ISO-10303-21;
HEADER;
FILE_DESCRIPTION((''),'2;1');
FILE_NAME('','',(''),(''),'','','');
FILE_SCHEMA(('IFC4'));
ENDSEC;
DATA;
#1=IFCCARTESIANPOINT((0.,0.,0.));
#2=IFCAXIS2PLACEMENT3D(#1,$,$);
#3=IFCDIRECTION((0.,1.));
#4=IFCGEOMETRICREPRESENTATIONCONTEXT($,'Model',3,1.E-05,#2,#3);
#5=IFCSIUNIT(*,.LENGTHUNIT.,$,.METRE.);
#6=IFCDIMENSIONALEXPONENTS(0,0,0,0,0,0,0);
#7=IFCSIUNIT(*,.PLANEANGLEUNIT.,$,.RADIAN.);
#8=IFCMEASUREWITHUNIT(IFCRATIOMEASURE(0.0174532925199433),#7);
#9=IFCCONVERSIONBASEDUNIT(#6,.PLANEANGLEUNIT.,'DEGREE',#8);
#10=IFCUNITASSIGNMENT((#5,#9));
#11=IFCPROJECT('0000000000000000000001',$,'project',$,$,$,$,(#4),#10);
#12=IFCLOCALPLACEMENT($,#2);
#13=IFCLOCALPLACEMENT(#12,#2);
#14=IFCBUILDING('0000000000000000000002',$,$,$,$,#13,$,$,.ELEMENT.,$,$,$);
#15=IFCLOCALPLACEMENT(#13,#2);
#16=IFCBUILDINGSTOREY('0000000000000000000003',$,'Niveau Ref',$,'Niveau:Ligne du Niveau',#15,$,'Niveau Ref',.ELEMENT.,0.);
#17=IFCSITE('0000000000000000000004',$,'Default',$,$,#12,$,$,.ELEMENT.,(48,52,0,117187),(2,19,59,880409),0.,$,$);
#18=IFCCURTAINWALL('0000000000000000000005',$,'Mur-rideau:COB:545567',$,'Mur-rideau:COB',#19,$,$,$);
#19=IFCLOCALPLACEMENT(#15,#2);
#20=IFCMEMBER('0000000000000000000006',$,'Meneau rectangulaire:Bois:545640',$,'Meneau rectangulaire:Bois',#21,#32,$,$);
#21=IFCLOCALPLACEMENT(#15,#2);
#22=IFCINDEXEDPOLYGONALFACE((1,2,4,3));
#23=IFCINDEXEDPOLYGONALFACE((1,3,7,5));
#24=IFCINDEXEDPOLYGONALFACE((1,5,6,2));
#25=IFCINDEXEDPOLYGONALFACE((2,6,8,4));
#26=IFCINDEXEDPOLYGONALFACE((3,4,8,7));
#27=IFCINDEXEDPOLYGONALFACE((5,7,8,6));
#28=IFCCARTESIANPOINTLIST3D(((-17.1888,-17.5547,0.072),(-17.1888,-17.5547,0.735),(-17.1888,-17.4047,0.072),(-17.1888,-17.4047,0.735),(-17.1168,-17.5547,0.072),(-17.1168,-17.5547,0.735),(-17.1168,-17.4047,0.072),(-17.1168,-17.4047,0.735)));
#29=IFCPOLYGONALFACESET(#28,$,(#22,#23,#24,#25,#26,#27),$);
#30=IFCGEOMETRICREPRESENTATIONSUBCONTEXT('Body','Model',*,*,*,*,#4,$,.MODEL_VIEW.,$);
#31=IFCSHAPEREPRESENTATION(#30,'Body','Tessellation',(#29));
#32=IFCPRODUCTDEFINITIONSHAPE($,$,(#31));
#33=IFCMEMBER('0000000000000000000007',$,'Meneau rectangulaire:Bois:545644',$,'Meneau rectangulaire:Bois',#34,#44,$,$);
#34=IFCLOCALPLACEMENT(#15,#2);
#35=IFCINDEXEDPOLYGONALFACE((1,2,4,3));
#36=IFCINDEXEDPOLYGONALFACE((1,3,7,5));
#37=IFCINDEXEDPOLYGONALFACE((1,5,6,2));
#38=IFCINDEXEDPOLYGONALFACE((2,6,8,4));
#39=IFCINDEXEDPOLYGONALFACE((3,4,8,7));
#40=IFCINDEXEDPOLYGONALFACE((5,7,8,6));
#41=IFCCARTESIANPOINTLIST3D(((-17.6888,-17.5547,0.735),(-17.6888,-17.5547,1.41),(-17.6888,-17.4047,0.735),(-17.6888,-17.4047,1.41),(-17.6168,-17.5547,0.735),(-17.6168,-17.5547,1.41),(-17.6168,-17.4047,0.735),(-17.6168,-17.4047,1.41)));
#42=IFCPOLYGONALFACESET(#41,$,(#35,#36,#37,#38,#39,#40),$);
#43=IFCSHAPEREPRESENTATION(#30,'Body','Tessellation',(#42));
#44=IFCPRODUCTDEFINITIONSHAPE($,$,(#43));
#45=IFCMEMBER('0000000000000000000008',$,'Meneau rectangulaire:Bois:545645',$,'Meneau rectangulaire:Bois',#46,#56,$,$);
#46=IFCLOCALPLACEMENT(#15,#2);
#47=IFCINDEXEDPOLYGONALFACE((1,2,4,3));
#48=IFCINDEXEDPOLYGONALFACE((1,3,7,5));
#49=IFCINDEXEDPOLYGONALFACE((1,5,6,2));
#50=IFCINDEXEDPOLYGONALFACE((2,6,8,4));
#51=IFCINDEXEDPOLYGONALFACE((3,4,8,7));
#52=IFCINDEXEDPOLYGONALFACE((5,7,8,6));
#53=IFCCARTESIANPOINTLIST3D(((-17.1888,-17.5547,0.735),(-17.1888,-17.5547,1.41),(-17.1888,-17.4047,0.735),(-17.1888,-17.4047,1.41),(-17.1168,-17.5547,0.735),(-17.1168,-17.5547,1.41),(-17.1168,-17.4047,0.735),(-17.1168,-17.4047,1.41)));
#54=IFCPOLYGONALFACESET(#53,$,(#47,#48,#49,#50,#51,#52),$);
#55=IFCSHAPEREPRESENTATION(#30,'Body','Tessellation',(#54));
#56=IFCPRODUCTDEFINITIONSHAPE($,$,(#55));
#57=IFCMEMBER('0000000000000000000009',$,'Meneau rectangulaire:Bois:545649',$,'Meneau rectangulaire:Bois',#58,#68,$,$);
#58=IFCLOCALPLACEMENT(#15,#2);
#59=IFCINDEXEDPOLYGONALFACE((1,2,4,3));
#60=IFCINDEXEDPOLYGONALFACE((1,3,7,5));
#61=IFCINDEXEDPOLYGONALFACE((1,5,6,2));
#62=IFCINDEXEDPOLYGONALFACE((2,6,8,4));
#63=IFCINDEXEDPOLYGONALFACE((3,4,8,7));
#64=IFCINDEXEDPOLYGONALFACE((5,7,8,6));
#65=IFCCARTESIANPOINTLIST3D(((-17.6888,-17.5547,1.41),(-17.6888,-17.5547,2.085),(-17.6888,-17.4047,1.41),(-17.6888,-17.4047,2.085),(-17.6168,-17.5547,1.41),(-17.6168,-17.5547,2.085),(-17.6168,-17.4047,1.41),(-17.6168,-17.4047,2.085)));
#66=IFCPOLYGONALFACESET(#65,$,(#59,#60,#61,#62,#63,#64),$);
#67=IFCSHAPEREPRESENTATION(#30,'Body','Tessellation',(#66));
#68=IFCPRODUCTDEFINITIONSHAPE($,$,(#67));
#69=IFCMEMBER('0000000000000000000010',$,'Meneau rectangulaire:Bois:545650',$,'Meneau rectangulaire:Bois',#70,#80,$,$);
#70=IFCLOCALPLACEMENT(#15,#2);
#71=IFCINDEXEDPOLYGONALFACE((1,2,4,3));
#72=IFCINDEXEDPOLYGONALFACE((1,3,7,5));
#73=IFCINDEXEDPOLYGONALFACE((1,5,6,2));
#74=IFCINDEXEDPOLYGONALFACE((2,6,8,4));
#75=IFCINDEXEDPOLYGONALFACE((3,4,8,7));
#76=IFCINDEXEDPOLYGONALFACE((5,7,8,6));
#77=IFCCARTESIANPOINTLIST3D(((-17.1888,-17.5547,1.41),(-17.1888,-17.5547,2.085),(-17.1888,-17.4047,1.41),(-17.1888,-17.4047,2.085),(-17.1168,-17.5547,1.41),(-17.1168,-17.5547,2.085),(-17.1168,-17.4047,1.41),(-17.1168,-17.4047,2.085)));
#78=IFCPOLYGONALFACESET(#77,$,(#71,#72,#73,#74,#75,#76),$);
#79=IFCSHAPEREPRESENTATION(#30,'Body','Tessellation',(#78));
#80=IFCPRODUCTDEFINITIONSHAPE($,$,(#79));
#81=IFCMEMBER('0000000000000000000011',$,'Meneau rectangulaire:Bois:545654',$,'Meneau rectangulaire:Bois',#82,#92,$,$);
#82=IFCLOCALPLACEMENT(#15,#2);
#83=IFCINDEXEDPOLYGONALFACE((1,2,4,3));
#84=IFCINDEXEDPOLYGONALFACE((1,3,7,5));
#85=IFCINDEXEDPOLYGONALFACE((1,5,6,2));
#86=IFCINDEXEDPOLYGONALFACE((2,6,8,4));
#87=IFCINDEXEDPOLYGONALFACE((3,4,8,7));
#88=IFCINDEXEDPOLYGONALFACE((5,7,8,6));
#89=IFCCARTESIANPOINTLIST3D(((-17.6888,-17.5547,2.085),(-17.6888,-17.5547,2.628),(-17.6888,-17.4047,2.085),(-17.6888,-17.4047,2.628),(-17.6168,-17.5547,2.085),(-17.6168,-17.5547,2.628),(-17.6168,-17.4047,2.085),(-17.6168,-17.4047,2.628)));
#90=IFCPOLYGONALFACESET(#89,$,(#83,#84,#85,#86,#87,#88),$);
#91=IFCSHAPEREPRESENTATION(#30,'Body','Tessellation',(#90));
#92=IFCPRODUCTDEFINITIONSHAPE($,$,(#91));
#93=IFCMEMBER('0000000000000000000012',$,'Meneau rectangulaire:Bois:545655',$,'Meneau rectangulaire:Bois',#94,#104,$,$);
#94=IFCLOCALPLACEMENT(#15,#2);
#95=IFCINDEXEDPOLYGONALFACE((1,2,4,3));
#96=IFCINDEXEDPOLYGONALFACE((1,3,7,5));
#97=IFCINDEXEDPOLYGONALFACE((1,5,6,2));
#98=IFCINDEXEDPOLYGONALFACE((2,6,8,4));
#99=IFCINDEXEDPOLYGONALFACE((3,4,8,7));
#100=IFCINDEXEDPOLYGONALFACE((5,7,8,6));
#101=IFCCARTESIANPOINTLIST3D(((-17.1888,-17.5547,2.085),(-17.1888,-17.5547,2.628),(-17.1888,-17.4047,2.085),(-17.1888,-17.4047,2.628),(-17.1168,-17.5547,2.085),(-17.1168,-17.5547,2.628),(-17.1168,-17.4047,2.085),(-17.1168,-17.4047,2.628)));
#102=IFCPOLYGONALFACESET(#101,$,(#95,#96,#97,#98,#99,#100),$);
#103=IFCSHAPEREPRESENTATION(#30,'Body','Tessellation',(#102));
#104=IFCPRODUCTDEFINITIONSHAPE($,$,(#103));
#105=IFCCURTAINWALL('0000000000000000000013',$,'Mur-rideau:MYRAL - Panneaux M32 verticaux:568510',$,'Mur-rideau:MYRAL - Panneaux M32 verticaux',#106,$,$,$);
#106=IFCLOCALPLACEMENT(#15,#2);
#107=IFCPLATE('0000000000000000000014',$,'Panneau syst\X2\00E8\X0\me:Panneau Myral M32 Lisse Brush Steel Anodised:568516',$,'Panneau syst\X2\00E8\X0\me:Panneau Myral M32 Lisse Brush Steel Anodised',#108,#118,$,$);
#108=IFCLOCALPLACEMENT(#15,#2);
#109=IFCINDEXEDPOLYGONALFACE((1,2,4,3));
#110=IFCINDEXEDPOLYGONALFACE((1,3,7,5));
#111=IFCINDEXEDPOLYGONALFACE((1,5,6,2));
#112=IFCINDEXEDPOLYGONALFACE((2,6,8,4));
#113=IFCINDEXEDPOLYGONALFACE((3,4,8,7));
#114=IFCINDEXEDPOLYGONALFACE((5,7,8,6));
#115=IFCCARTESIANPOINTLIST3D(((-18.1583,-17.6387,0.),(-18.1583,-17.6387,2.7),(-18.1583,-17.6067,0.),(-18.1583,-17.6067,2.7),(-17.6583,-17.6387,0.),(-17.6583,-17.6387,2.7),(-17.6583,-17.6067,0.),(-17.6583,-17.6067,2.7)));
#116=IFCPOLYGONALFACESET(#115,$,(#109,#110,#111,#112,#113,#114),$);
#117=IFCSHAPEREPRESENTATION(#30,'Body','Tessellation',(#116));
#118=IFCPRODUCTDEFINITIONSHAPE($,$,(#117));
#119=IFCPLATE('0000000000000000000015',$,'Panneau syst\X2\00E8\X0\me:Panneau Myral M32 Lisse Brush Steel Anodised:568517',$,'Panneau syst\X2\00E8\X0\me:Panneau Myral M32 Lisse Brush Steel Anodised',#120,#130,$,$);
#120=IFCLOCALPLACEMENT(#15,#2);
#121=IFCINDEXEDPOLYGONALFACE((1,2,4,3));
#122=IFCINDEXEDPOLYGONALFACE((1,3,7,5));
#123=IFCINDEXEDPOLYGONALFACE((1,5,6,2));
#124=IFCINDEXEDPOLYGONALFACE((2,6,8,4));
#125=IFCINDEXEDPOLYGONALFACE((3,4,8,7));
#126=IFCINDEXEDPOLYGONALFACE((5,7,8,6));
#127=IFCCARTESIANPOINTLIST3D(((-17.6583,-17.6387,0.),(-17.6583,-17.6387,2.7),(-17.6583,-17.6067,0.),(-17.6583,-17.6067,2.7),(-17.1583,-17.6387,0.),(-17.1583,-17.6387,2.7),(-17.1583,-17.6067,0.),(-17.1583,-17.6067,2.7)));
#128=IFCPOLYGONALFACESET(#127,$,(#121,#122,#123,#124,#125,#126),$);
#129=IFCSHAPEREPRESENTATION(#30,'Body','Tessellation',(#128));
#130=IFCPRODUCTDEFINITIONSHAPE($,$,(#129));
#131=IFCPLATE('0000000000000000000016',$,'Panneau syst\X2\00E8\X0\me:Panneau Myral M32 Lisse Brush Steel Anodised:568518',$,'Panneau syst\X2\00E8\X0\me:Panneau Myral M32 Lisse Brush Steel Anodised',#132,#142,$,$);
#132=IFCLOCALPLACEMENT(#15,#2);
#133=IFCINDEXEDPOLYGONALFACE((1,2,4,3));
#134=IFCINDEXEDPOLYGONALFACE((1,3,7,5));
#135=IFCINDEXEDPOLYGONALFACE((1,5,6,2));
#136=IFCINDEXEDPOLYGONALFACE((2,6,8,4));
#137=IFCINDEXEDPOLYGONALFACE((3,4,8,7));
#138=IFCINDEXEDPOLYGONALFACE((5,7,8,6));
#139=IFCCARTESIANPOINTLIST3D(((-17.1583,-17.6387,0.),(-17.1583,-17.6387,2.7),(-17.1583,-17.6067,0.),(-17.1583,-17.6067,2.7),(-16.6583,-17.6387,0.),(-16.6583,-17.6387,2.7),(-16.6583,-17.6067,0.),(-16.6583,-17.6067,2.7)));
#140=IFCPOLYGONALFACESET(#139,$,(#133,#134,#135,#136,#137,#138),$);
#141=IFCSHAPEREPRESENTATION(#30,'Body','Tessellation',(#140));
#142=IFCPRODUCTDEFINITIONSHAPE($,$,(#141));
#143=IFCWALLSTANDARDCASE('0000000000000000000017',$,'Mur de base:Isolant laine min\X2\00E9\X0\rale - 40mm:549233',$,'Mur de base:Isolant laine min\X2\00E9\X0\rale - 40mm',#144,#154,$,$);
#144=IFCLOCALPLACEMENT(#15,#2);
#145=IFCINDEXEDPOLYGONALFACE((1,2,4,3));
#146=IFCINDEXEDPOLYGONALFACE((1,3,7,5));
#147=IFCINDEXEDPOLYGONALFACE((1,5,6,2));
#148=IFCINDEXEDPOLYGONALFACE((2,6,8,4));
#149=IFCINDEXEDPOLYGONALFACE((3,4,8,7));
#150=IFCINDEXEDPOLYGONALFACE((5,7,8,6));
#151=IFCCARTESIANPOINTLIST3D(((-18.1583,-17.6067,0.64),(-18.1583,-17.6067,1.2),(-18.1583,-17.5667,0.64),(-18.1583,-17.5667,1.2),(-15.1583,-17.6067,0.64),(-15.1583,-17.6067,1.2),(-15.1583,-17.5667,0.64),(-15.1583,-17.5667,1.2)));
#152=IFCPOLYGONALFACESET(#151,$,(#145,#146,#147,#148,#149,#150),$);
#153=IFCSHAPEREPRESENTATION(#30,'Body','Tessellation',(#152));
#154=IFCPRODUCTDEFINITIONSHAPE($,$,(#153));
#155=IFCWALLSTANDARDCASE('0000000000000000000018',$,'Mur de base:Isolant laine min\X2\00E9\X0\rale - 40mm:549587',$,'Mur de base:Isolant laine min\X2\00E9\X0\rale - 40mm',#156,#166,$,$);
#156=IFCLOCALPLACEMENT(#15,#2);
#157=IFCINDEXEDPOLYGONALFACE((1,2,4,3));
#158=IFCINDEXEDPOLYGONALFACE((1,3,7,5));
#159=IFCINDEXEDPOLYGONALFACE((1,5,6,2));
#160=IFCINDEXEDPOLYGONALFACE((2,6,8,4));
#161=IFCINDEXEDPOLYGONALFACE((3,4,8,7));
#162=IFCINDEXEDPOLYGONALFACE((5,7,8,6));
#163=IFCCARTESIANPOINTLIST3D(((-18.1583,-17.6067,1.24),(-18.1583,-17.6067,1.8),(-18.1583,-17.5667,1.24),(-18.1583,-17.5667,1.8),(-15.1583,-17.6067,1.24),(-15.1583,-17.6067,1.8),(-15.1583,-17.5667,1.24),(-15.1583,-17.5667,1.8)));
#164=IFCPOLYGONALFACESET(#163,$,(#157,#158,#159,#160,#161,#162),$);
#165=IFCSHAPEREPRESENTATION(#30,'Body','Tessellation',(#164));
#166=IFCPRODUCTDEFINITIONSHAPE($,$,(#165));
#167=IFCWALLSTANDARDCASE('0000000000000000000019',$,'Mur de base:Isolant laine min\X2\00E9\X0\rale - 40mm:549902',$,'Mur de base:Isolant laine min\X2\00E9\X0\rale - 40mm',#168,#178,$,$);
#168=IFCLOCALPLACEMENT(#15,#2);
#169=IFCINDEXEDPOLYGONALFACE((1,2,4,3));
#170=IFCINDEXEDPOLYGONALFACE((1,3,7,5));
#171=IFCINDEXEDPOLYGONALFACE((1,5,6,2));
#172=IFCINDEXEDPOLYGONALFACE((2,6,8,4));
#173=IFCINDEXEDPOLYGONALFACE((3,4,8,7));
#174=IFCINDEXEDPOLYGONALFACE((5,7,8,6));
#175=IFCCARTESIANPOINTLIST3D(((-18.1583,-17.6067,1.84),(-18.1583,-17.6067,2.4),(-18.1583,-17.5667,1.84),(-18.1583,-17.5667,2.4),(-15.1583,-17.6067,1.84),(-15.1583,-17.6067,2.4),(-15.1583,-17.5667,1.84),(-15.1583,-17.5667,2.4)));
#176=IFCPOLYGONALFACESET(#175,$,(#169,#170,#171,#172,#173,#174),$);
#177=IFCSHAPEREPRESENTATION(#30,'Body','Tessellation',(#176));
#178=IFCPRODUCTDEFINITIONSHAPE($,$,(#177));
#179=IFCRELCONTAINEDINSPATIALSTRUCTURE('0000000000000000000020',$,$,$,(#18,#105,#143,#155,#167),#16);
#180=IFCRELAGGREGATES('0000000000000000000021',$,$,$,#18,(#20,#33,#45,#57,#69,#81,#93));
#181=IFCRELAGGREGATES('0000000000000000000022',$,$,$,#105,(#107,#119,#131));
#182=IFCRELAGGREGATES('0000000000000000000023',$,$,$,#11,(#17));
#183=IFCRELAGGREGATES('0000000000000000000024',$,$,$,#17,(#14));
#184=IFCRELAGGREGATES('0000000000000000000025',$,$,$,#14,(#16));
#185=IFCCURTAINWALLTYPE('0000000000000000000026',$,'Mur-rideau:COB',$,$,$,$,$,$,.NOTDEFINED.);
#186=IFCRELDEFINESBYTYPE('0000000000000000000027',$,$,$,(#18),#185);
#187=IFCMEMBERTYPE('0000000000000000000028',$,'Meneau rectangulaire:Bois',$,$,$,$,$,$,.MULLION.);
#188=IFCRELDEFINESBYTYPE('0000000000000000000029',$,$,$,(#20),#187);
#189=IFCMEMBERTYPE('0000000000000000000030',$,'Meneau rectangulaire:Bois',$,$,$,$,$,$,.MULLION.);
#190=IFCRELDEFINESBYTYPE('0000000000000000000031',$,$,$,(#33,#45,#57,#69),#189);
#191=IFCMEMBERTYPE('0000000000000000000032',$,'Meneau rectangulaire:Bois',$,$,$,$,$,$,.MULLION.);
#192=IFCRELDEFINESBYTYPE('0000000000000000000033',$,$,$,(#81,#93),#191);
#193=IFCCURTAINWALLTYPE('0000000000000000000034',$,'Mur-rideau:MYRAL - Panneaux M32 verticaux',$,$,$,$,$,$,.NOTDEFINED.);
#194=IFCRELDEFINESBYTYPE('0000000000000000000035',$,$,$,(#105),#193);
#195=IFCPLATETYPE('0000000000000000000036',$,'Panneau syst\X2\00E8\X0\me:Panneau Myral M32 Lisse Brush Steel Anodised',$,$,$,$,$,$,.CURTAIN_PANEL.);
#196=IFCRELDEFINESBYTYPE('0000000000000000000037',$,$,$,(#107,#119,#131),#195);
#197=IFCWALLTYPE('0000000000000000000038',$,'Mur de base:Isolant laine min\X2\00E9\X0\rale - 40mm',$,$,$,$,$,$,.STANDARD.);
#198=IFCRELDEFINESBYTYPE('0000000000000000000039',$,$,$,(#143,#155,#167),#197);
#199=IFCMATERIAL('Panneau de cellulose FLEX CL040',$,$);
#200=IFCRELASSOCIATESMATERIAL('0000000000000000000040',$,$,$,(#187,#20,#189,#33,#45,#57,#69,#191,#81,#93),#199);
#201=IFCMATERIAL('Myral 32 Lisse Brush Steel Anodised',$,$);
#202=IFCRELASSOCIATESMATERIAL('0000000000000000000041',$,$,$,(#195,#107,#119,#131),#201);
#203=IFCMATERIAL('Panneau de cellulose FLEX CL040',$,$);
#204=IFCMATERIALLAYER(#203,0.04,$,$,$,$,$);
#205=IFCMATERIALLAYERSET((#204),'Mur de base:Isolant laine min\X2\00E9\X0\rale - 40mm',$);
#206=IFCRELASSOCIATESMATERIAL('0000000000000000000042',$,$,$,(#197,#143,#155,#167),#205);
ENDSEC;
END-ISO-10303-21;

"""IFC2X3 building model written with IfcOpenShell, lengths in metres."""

from ifc_helpers import new_model, entity, si_unit, converted_unit, direction, frame, frame_2d, origin, origin_2d_with_axis, place, context, subcontext, project, spatial, rectangle, extrude, source, transform, mapped, material, layer, layer_set, layer_usage, type_object, type_shapes, element, aggregate, save


model = new_model("IFC2X3")

# Units and contexts
model_context = context("Model", 3, precision=1e-05, world=origin(), true_north=direction((0.0, 1.0)))
body_context = subcontext(model_context, "Body", "Model", "MODEL_VIEW")
ifc_project = project(units=[si_unit("LENGTHUNIT", "METRE"), converted_unit("PLANEANGLEUNIT", "DEGREE", entity("IfcRatioMeasure", 0.0174532925199433), si_unit("PLANEANGLEUNIT", "RADIAN"), dimensions=[0, 0, 0, 0, 0, 0, 0])], contexts=[model_context])

# Site, building, storey
site_placement = place(None, origin())
site = spatial("IfcSite", under=ifc_project, at=site_placement, Name="Default", CompositionType="ELEMENT", RefLatitude=(48, 52, 0, 117187), RefLongitude=(2, 19, 59, 880409), RefElevation=0.0)
building_placement = place(site_placement, origin())
building = spatial("IfcBuilding", under=site, at=building_placement, CompositionType="ELEMENT")
storey_placement = place(building_placement, origin())
storey = spatial("IfcBuildingStorey", under=building, at=storey_placement, Name="Niveau Ref", ObjectType="Niveau:Ligne du Niveau", LongName="Niveau Ref", CompositionType="ELEMENT", Elevation=0.0)

# Curtain wall, members
curtain_wall_type_1 = type_object("IfcCurtainWallType", Name="Mur-rideau:COB", PredefinedType="NOTDEFINED")
curtain_wall_1_placement = place(storey_placement, origin())
curtain_wall_1 = element("IfcCurtainWall", 1, at=curtain_wall_1_placement, inside=storey, type_object=curtain_wall_type_1, Name="Mur-rideau:COB:545567", ObjectType="Mur-rideau:COB")
ifc_material_1 = material(Name="Panneau de cellulose FLEX CL040")
member_type_1 = type_object("IfcMemberType", Name="Meneau rectangulaire:Bois", PredefinedType="MULLION", material=ifc_material_1)
shared_shape_1 = source(origin(), body_context, "Body", "SweptSolid", [
    extrude(rectangle(XDim=0.15, YDim=0.072, at=origin_2d_with_axis()), frame((-0.024, 0.0, -0.663), z_axis=(0.0, 0.0, 1.0), x_axis=(0.0, -1.0, 0.0)), (0.0, 0.0, 1.0), 0.663),
])
type_shapes(member_type_1, [shared_shape_1])
member_1_placement = place(storey_placement, frame((-17.1288, -17.4797, 0.072), z_axis=(0.0, 0.0, -1.0), x_axis=(1.0, 0.0, 0.0)))
member_1 = element("IfcMember", 2, at=member_1_placement, type_object=member_type_1, material=ifc_material_1, Name="Meneau rectangulaire:Bois:545640", ObjectType="Meneau rectangulaire:Bois", context=body_context, shape_type="MappedRepresentation", body=[
    mapped(shared_shape_1, transform((0.0, 0.0, 0.0), scale=1.0)),
])
member_type_2 = type_object("IfcMemberType", Name="Meneau rectangulaire:Bois", PredefinedType="MULLION", material=ifc_material_1)
shared_shape_2 = source(origin(), body_context, "Body", "SweptSolid", [
    extrude(rectangle(XDim=0.15, YDim=0.072, at=origin_2d_with_axis()), frame((-0.024, 0.0, -0.675), z_axis=(0.0, 0.0, 1.0), x_axis=(0.0, -1.0, 0.0)), (0.0, 0.0, 1.0), 0.675),
])
type_shapes(member_type_2, [shared_shape_2])
member_2_placement = place(storey_placement, frame((-17.6288, -17.4797, 0.735), z_axis=(0.0, 0.0, -1.0), x_axis=(1.0, 0.0, 0.0)))
member_2 = element("IfcMember", 3, at=member_2_placement, type_object=member_type_2, material=ifc_material_1, Name="Meneau rectangulaire:Bois:545644", ObjectType="Meneau rectangulaire:Bois", context=body_context, shape_type="MappedRepresentation", body=[
    mapped(shared_shape_2, transform((0.0, 0.0, 0.0), scale=1.0)),
])
member_3_placement = place(storey_placement, frame((-17.1288, -17.4797, 0.735), z_axis=(0.0, 0.0, -1.0), x_axis=(1.0, 0.0, 0.0)))
member_3 = element("IfcMember", 4, at=member_3_placement, type_object=member_type_2, material=ifc_material_1, Name="Meneau rectangulaire:Bois:545645", ObjectType="Meneau rectangulaire:Bois", context=body_context, shape_type="MappedRepresentation", body=[
    mapped(shared_shape_2, transform((0.0, 0.0, 0.0), scale=1.0)),
])
member_4_placement = place(storey_placement, frame((-17.6288, -17.4797, 1.41), z_axis=(0.0, 0.0, -1.0), x_axis=(1.0, 0.0, 0.0)))
member_4 = element("IfcMember", 5, at=member_4_placement, type_object=member_type_2, material=ifc_material_1, Name="Meneau rectangulaire:Bois:545649", ObjectType="Meneau rectangulaire:Bois", context=body_context, shape_type="MappedRepresentation", body=[
    mapped(shared_shape_2, transform((0.0, 0.0, 0.0), scale=1.0)),
])
member_5_placement = place(storey_placement, frame((-17.1288, -17.4797, 1.41), z_axis=(0.0, 0.0, -1.0), x_axis=(1.0, 0.0, 0.0)))
member_5 = element("IfcMember", 6, at=member_5_placement, type_object=member_type_2, material=ifc_material_1, Name="Meneau rectangulaire:Bois:545650", ObjectType="Meneau rectangulaire:Bois", context=body_context, shape_type="MappedRepresentation", body=[
    mapped(shared_shape_2, transform((0.0, 0.0, 0.0), scale=1.0)),
])
member_type_3 = type_object("IfcMemberType", Name="Meneau rectangulaire:Bois", PredefinedType="MULLION", material=ifc_material_1)
shared_shape_3 = source(origin(), body_context, "Body", "SweptSolid", [
    extrude(rectangle(XDim=0.15, YDim=0.072, at=origin_2d_with_axis()), frame((-0.024, 0.0, -0.543), z_axis=(0.0, 0.0, 1.0), x_axis=(0.0, -1.0, 0.0)), (0.0, 0.0, 1.0), 0.543),
])
type_shapes(member_type_3, [shared_shape_3])
member_6_placement = place(storey_placement, frame((-17.6288, -17.4797, 2.085), z_axis=(0.0, 0.0, -1.0), x_axis=(1.0, 0.0, 0.0)))
member_6 = element("IfcMember", 7, at=member_6_placement, type_object=member_type_3, material=ifc_material_1, Name="Meneau rectangulaire:Bois:545654", ObjectType="Meneau rectangulaire:Bois", context=body_context, shape_type="MappedRepresentation", body=[
    mapped(shared_shape_3, transform((0.0, 0.0, 0.0), scale=1.0)),
])
member_7_placement = place(storey_placement, frame((-17.1288, -17.4797, 2.085), z_axis=(0.0, 0.0, -1.0), x_axis=(1.0, 0.0, 0.0)))
member_7 = element("IfcMember", 8, at=member_7_placement, type_object=member_type_3, material=ifc_material_1, Name="Meneau rectangulaire:Bois:545655", ObjectType="Meneau rectangulaire:Bois", context=body_context, shape_type="MappedRepresentation", body=[
    mapped(shared_shape_3, transform((0.0, 0.0, 0.0), scale=1.0)),
])
aggregate(curtain_wall_1, [member_1, member_2, member_3, member_4, member_5, member_6, member_7])

# Curtain wall, plates
curtain_wall_type_2 = type_object("IfcCurtainWallType", Name="Mur-rideau:MYRAL - Panneaux M32 verticaux", PredefinedType="NOTDEFINED")
curtain_wall_2_placement = place(storey_placement, origin())
curtain_wall_2 = element("IfcCurtainWall", 9, at=curtain_wall_2_placement, inside=storey, type_object=curtain_wall_type_2, Name="Mur-rideau:MYRAL - Panneaux M32 verticaux:568510", ObjectType="Mur-rideau:MYRAL - Panneaux M32 verticaux")
ifc_material_2 = material(Name="Myral 32 Lisse Brush Steel Anodised")
plate_type = type_object("IfcPlateType", Name="Panneau système:Panneau Myral M32 Lisse Brush Steel Anodised", PredefinedType="CURTAIN_PANEL", material=ifc_material_2)
shared_shape_4 = source(origin(), body_context, "Body", "SweptSolid", [
    extrude(rectangle(XDim=0.032, YDim=0.5, at=origin_2d_with_axis()), frame((0.0, -0.016, 0.0), z_axis=(0.0, 0.0, 1.0), x_axis=(0.0, 1.0, 0.0)), (0.0, 0.0, 1.0), 2.7),
])
type_shapes(plate_type, [shared_shape_4])
plate_1_placement = place(curtain_wall_2_placement, frame((-17.9083, -17.6067, 0.0)))
plate_1 = element("IfcPlate", 10, at=plate_1_placement, type_object=plate_type, material=ifc_material_2, Name="Panneau système:Panneau Myral M32 Lisse Brush Steel Anodised:568516", ObjectType="Panneau système:Panneau Myral M32 Lisse Brush Steel Anodised", context=body_context, shape_type="MappedRepresentation", body=[
    mapped(shared_shape_4, transform((0.0, 0.0, 0.0), scale=1.0)),
])
plate_2_placement = place(curtain_wall_2_placement, frame((-17.4083, -17.6067, 0.0)))
plate_2 = element("IfcPlate", 11, at=plate_2_placement, type_object=plate_type, material=ifc_material_2, Name="Panneau système:Panneau Myral M32 Lisse Brush Steel Anodised:568517", ObjectType="Panneau système:Panneau Myral M32 Lisse Brush Steel Anodised", context=body_context, shape_type="MappedRepresentation", body=[
    mapped(shared_shape_4, transform((0.0, 0.0, 0.0), scale=1.0)),
])
plate_3_placement = place(curtain_wall_2_placement, frame((-16.9083, -17.6067, 0.0)))
plate_3 = element("IfcPlate", 12, at=plate_3_placement, type_object=plate_type, material=ifc_material_2, Name="Panneau système:Panneau Myral M32 Lisse Brush Steel Anodised:568518", ObjectType="Panneau système:Panneau Myral M32 Lisse Brush Steel Anodised", context=body_context, shape_type="MappedRepresentation", body=[
    mapped(shared_shape_4, transform((0.0, 0.0, 0.0), scale=1.0)),
])
aggregate(curtain_wall_2, [plate_1, plate_2, plate_3])

# Walls
ifc_material_3 = material(Name="Panneau de cellulose FLEX CL040")
ifc_layer = layer(ifc_material_3, 0.04)
ifc_layer_set = layer_set([ifc_layer], Name="Mur de base:Isolant laine minérale - 40mm")
ifc_layer_usage_1 = layer_usage(ifc_layer_set, "AXIS2", "NEGATIVE", 0.02)
wall_type = type_object("IfcWallType", Name="Mur de base:Isolant laine minérale - 40mm", PredefinedType="STANDARD", material=ifc_layer_set)
wall_1_placement = place(storey_placement, frame((-18.1583, -17.5867, 0.64)))
element("IfcWallStandardCase", 13, at=wall_1_placement, inside=storey, type_object=wall_type, material=ifc_layer_usage_1, Name="Mur de base:Isolant laine minérale - 40mm:549233", ObjectType="Mur de base:Isolant laine minérale - 40mm", context=body_context, shape_type="SweptSolid", body=[
    extrude(rectangle(XDim=3.0, YDim=0.04, at=frame_2d((1.5, 0.0), x_axis=(-1.0, 0.0))), origin(), (0.0, 0.0, 1.0), 0.56),
])
ifc_layer_usage_2 = layer_usage(ifc_layer_set, "AXIS2", "NEGATIVE", 0.02)
wall_2_placement = place(storey_placement, frame((-18.1583, -17.5867, 1.24)))
element("IfcWallStandardCase", 14, at=wall_2_placement, inside=storey, type_object=wall_type, material=ifc_layer_usage_2, Name="Mur de base:Isolant laine minérale - 40mm:549587", ObjectType="Mur de base:Isolant laine minérale - 40mm", context=body_context, shape_type="SweptSolid", body=[
    extrude(rectangle(XDim=3.0, YDim=0.04, at=frame_2d((1.5, 0.0), x_axis=(-1.0, 0.0))), origin(), (0.0, 0.0, 1.0), 0.56),
])
ifc_layer_usage_3 = layer_usage(ifc_layer_set, "AXIS2", "NEGATIVE", 0.02)
wall_3_placement = place(storey_placement, frame((-18.1583, -17.5867, 1.84)))
element("IfcWallStandardCase", 15, at=wall_3_placement, inside=storey, type_object=wall_type, material=ifc_layer_usage_3, Name="Mur de base:Isolant laine minérale - 40mm:549902", ObjectType="Mur de base:Isolant laine minérale - 40mm", context=body_context, shape_type="SweptSolid", body=[
    extrude(rectangle(XDim=3.0, YDim=0.04, at=frame_2d((1.5, 0.0), x_axis=(-1.0, 0.0))), origin(), (0.0, 0.0, 1.0), 0.56),
])

save(model, "model.ifc")
